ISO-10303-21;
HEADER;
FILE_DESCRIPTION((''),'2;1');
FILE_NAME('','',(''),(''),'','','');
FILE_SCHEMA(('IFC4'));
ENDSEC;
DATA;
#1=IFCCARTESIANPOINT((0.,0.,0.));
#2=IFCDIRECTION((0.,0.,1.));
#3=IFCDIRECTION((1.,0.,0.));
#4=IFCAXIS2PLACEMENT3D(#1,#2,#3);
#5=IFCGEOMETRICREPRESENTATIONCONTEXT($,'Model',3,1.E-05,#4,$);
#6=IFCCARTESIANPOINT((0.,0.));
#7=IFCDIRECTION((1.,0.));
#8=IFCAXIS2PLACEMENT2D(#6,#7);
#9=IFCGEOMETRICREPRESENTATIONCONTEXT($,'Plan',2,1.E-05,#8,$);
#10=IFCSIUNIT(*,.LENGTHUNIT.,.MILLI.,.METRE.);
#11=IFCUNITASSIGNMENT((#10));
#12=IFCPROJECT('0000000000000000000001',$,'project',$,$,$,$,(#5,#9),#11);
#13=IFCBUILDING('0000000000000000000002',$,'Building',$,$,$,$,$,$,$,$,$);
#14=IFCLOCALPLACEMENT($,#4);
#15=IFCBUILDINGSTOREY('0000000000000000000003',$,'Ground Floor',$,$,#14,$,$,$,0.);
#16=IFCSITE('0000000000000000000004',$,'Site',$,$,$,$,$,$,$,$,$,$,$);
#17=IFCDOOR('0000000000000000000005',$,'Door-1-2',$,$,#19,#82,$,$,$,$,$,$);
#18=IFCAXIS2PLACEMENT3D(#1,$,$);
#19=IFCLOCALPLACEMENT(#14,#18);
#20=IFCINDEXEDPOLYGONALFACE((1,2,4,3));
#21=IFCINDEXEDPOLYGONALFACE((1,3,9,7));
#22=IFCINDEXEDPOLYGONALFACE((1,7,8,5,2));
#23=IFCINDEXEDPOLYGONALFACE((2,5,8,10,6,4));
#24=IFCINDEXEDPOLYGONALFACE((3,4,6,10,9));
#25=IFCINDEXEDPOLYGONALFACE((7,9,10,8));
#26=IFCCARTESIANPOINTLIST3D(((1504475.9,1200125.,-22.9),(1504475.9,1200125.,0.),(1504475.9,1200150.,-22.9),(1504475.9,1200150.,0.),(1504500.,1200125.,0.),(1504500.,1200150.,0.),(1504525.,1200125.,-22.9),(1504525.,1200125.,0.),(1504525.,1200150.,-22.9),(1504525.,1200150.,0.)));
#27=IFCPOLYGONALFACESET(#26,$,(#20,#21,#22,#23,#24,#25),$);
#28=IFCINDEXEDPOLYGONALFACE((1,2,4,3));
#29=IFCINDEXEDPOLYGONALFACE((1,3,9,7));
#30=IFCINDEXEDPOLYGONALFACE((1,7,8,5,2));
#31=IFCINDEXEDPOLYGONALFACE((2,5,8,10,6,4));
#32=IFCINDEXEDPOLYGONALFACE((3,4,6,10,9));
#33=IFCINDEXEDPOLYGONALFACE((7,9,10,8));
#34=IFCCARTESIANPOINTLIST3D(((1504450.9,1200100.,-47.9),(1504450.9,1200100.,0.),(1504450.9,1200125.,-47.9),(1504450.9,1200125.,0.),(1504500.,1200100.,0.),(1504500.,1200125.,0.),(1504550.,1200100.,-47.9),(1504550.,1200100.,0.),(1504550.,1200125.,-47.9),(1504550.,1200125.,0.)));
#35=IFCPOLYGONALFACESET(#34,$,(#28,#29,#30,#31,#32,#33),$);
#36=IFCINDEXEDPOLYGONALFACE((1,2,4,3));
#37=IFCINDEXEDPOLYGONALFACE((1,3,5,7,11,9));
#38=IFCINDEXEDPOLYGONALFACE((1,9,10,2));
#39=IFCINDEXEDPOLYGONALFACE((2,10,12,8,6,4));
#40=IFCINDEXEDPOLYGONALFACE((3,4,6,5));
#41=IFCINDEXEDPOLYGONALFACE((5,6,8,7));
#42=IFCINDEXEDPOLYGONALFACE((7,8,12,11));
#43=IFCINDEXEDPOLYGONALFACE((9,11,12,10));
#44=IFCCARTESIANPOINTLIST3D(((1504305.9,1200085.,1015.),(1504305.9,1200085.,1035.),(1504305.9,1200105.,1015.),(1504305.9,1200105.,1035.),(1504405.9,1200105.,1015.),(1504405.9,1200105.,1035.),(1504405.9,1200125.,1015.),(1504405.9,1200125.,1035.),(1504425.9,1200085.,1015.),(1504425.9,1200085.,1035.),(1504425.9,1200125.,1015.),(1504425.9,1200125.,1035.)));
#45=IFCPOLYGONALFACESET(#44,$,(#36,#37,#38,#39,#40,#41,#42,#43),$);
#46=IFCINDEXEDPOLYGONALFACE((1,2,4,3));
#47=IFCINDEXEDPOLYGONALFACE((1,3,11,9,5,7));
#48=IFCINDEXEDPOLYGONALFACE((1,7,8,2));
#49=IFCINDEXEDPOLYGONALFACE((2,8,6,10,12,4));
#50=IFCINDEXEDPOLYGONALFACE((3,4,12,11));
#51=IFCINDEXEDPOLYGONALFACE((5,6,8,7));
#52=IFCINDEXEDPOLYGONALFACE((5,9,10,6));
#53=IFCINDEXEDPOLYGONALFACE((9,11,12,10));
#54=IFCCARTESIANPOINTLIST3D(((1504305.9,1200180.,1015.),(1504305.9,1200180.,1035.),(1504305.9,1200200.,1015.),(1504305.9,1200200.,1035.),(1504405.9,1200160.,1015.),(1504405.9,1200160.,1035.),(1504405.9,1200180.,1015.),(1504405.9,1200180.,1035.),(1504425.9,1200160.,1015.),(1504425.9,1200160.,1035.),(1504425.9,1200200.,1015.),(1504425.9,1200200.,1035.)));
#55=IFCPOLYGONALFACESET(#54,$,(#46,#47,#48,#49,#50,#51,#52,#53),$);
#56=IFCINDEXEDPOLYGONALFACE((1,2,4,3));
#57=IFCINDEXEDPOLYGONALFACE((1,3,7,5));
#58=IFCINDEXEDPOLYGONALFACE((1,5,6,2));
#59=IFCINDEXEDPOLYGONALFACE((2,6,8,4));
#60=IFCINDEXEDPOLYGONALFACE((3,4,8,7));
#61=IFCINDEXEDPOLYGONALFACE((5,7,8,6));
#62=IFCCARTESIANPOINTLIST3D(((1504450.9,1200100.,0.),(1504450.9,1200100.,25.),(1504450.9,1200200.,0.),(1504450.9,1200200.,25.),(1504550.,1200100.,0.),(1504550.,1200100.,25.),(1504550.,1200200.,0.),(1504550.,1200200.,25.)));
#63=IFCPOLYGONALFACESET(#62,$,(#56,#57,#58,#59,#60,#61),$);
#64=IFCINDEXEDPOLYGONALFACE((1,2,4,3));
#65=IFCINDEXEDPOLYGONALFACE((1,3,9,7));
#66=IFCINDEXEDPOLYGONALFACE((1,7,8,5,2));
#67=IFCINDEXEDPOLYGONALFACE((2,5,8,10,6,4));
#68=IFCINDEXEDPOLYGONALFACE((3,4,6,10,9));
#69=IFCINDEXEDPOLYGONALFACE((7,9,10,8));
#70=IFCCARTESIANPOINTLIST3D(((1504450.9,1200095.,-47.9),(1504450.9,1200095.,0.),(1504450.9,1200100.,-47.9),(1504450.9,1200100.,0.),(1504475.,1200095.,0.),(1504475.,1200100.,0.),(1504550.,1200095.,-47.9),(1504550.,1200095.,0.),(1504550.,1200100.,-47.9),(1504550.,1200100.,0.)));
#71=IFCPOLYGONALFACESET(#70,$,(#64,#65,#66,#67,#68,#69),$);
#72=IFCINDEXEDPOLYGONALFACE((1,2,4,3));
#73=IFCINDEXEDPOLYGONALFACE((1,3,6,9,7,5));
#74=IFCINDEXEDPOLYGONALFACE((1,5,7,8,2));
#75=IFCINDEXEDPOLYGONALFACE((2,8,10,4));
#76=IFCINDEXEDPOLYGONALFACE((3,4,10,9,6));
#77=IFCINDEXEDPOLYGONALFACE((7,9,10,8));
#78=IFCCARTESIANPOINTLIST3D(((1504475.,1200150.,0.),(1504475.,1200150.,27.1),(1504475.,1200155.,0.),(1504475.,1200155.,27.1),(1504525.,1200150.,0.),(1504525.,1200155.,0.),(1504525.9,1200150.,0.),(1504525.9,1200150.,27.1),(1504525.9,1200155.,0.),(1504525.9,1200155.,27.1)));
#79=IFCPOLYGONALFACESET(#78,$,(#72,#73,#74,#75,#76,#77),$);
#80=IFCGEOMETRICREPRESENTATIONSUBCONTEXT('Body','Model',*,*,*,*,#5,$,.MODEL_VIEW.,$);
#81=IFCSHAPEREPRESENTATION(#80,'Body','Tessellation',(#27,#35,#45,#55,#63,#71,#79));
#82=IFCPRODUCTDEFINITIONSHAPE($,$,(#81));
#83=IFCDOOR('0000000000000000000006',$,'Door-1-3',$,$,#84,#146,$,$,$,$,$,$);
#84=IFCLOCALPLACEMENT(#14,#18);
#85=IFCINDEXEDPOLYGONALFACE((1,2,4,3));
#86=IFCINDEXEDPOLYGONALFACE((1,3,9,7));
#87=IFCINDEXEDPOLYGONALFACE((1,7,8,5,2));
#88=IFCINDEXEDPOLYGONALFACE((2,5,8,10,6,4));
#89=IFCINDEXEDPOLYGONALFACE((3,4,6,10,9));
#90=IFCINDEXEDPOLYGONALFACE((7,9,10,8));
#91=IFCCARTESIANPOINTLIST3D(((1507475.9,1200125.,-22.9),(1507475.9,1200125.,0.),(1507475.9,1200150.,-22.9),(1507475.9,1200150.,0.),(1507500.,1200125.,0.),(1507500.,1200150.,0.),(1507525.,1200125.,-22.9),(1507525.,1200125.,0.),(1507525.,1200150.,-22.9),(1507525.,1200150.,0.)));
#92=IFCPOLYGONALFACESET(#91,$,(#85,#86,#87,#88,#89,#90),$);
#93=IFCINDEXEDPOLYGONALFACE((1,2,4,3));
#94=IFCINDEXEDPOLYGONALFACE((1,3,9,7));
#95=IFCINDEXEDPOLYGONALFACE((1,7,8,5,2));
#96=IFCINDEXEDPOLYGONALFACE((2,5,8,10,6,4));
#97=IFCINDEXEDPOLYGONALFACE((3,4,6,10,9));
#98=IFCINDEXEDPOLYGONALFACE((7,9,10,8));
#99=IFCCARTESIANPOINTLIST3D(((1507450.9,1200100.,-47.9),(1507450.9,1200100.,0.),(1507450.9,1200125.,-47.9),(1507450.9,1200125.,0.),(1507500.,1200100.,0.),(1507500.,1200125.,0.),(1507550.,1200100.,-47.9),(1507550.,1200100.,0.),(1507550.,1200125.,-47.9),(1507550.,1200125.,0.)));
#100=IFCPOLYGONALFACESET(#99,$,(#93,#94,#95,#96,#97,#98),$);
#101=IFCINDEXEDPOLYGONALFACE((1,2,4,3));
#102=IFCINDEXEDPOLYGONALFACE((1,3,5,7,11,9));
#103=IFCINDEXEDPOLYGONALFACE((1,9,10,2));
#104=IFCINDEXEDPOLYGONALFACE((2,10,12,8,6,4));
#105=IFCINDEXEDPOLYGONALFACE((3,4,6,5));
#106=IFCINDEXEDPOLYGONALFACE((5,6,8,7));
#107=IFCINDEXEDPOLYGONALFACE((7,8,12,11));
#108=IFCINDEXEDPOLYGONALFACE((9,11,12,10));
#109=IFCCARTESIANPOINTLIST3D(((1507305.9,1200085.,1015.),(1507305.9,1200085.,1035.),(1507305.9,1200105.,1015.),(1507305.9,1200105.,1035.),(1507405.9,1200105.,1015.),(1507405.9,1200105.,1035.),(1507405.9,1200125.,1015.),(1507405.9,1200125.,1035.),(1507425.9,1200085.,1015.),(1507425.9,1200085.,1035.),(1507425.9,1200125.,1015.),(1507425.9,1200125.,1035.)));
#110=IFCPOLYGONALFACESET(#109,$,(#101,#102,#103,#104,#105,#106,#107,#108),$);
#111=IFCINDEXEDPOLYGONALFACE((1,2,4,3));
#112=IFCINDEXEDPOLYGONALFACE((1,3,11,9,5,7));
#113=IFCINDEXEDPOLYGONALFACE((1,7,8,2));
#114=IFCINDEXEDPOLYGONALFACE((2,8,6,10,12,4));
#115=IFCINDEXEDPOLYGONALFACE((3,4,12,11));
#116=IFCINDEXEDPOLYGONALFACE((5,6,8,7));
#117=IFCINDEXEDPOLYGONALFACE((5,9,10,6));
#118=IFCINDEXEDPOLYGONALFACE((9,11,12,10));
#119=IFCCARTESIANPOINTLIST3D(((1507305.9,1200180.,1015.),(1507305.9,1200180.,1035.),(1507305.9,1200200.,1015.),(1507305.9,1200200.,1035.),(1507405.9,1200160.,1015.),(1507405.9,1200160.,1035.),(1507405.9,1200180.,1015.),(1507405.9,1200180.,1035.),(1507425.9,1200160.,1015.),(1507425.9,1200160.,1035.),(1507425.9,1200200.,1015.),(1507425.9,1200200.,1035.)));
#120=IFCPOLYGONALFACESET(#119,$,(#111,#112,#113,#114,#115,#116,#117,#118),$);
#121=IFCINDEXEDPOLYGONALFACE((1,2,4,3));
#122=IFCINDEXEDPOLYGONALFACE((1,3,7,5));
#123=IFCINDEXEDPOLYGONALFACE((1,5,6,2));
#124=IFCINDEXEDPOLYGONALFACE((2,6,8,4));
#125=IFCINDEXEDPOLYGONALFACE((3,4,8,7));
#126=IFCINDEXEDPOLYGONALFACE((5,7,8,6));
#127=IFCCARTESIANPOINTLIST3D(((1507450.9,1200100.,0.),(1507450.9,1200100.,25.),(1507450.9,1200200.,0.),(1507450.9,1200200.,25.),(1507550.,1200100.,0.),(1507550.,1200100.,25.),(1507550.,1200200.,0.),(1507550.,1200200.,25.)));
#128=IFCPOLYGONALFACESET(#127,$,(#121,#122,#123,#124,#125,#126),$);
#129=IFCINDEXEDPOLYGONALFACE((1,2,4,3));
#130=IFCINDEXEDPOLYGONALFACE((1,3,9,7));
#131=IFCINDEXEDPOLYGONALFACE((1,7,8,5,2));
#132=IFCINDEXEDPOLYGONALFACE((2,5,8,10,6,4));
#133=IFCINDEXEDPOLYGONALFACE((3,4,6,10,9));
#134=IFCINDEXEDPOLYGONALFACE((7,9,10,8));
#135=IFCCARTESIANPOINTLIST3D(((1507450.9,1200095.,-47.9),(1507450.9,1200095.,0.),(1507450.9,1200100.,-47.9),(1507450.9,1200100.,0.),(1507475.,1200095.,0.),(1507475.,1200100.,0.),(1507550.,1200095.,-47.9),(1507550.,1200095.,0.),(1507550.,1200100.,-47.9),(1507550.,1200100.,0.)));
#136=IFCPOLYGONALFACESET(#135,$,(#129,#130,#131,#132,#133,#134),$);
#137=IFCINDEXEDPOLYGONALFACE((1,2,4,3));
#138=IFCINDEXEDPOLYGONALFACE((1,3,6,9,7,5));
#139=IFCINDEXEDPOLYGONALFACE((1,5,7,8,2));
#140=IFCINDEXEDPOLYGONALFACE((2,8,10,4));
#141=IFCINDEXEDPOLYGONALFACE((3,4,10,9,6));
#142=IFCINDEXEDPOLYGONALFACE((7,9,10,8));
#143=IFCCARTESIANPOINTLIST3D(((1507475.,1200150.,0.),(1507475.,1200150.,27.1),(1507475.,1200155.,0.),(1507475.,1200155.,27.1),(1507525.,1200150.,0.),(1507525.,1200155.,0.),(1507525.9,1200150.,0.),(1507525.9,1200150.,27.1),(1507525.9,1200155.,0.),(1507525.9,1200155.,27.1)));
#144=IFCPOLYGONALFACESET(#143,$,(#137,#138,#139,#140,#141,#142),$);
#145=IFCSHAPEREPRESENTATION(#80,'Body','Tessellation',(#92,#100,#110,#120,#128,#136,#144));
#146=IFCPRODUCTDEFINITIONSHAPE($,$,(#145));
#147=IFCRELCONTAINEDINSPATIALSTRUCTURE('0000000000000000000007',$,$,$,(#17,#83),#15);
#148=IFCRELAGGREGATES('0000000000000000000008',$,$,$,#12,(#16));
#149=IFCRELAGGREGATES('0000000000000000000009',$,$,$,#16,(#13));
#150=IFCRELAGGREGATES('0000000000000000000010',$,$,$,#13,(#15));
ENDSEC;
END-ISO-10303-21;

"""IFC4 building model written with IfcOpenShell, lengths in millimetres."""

from ifc_helpers import new_model, si_unit, frame, origin_with_axes, origin_2d_with_axis, place, context, subcontext, project, spatial, line, indexed_curve, outline, extrude, element, save


model = new_model("IFC4")

# Units and contexts
model_context = context("Model", 3, precision=1e-05, world=origin_with_axes())
plan_context = context("Plan", 2, precision=1e-05, world=origin_2d_with_axis())
body_context = subcontext(model_context, "Body", "Model", "MODEL_VIEW")
ifc_project = project(units=[si_unit("LENGTHUNIT", "METRE", prefix="MILLI")], contexts=[model_context, plan_context])

# Site, building, storey
site = spatial("IfcSite", under=ifc_project, Name="Site")
building = spatial("IfcBuilding", under=site, Name="Building")
storey_placement = place(None, origin_with_axes())
storey = spatial("IfcBuildingStorey", under=building, at=storey_placement, Name="Ground Floor", Elevation=0.0)

# Doors
door_1_placement = place(storey_placement, frame((1504500.0, 1200100.0, 0.0), z_axis=(0.0, 0.0, 1.0), x_axis=(1.0, 0.0, 0.0)))
element("IfcDoor", 1, at=door_1_placement, inside=storey, Name="Door-1-2", context=body_context, shape_type="SweptSolid", body=[
    extrude(outline(indexed_curve([(0.0, 0.0), (0.0, 2.1), (0.9, 2.1), (0.9, 0.0), (-24.1, 0.0), (-24.1, -22.9), (25.0, -22.9), (25.0, 0.0)], segments=[line(1, 2, 3, 4, 5, 6, 7, 8, 1)])), frame((0.0, 25.0, 0.0), z_axis=(0.0, -1.0, 0.0), x_axis=(1.0, 0.0, 0.0)), (0.0, 0.0, -1.0), 25.0),
    extrude(outline(indexed_curve([(0.0, 0.0), (0.0, 2.1), (0.9, 2.1), (0.9, 0.0), (-49.1, 0.0), (-49.1, -47.9), (50.0, -47.9), (50.0, 0.0)], segments=[line(1, 2, 3, 4, 5, 6, 7, 8, 1)])), frame((0.0, 0.0, 0.0), z_axis=(0.0, -1.0, 0.0), x_axis=(1.0, 0.0, 0.0)), (0.0, 0.0, -1.0), 25.0),
    extrude(outline(indexed_curve([(0.0, 0.0), (-49.1, 0.0), (-49.1, 35.0), (0.0, 35.0)], segments=[line(1, 2, 3, 4, 1)])), frame((25.0, 25.0, 25.0), z_axis=(0.0, 0.0, 1.0), x_axis=(1.0, 0.0, 0.0)), (0.0, 0.0, 1.0), -47.9),
    extrude(outline(indexed_curve([(0.0, 0.0), (0.0, -40.0), (-120.0, -40.0), (-120.0, -20.0), (-20.0, -20.0), (-20.0, 0.0)], segments=[line(1, 2, 3, 4, 5, 6, 1)])), frame((-74.1, 25.0, 1015.0), z_axis=(0.0, 0.0, 1.0), x_axis=(1.0, 0.0, 0.0)), (0.0, 0.0, 1.0), 20.0),
    extrude(outline(indexed_curve([(0.0, 0.0), (0.0, 40.0), (-120.0, 40.0), (-120.0, 20.0), (-20.0, 20.0), (-20.0, 0.0)], segments=[line(1, 2, 3, 4, 5, 6, 1)])), frame((-74.1, 60.0, 1015.0), z_axis=(0.0, 0.0, 1.0), x_axis=(1.0, 0.0, 0.0)), (0.0, 0.0, 1.0), 20.0),
    extrude(outline(indexed_curve([(0.0, 0.0), (-99.1, 0.0), (-99.1, 100.0), (0.0, 100.0)], segments=[line(1, 2, 3, 4, 1)])), frame((50.0, 0.0, 0.0), z_axis=(0.0, 0.0, 1.0), x_axis=(1.0, 0.0, 0.0)), (0.0, 0.0, 1.0), 25.0),
    extrude(outline(indexed_curve([(0.0, 0.0), (0.0, 27.1), (50.9, 27.1), (50.9, 0.0), (-24.1, 0.0), (-24.1, -47.9), (75.0, -47.9), (75.0, 0.0)], segments=[line(1, 2, 3, 4, 5, 6, 7, 8, 1)])), frame((-25.0, -5.0, 0.0), z_axis=(0.0, -1.0, 0.0), x_axis=(1.0, 0.0, 0.0)), (0.0, 0.0, -1.0), 5.0),
    extrude(outline(indexed_curve([(0.0, 0.0), (0.0, 27.1), (50.9, 27.1), (50.9, 0.0), (0.9, 0.0), (0.9, -22.9), (50.0, -22.9), (50.0, 0.0)], segments=[line(1, 2, 3, 4, 5, 6, 7, 8, 1)])), frame((-25.0, 50.0, 0.0), z_axis=(0.0, -1.0, 0.0), x_axis=(1.0, 0.0, 0.0)), (0.0, 0.0, -1.0), 5.0),
])
door_2_placement = place(storey_placement, frame((1507500.0, 1200100.0, 0.0), z_axis=(0.0, 0.0, 1.0), x_axis=(1.0, 0.0, 0.0)))
element("IfcDoor", 2, at=door_2_placement, inside=storey, Name="Door-1-3", context=body_context, shape_type="SweptSolid", body=[
    extrude(outline(indexed_curve([(0.0, 0.0), (0.0, 2.1), (0.9, 2.1), (0.9, 0.0), (-24.1, 0.0), (-24.1, -22.9), (25.0, -22.9), (25.0, 0.0)], segments=[line(1, 2, 3, 4, 5, 6, 7, 8, 1)])), frame((0.0, 25.0, 0.0), z_axis=(0.0, -1.0, 0.0), x_axis=(1.0, 0.0, 0.0)), (0.0, 0.0, -1.0), 25.0),
    extrude(outline(indexed_curve([(0.0, 0.0), (0.0, 2.1), (0.9, 2.1), (0.9, 0.0), (-49.1, 0.0), (-49.1, -47.9), (50.0, -47.9), (50.0, 0.0)], segments=[line(1, 2, 3, 4, 5, 6, 7, 8, 1)])), frame((0.0, 0.0, 0.0), z_axis=(0.0, -1.0, 0.0), x_axis=(1.0, 0.0, 0.0)), (0.0, 0.0, -1.0), 25.0),
    extrude(outline(indexed_curve([(0.0, 0.0), (-49.1, 0.0), (-49.1, 35.0), (0.0, 35.0)], segments=[line(1, 2, 3, 4, 1)])), frame((25.0, 25.0, 25.0), z_axis=(0.0, 0.0, 1.0), x_axis=(1.0, 0.0, 0.0)), (0.0, 0.0, 1.0), -47.9),
    extrude(outline(indexed_curve([(0.0, 0.0), (0.0, -40.0), (-120.0, -40.0), (-120.0, -20.0), (-20.0, -20.0), (-20.0, 0.0)], segments=[line(1, 2, 3, 4, 5, 6, 1)])), frame((-74.1, 25.0, 1015.0), z_axis=(0.0, 0.0, 1.0), x_axis=(1.0, 0.0, 0.0)), (0.0, 0.0, 1.0), 20.0),
    extrude(outline(indexed_curve([(0.0, 0.0), (0.0, 40.0), (-120.0, 40.0), (-120.0, 20.0), (-20.0, 20.0), (-20.0, 0.0)], segments=[line(1, 2, 3, 4, 5, 6, 1)])), frame((-74.1, 60.0, 1015.0), z_axis=(0.0, 0.0, 1.0), x_axis=(1.0, 0.0, 0.0)), (0.0, 0.0, 1.0), 20.0),
    extrude(outline(indexed_curve([(0.0, 0.0), (-99.1, 0.0), (-99.1, 100.0), (0.0, 100.0)], segments=[line(1, 2, 3, 4, 1)])), frame((50.0, 0.0, 0.0), z_axis=(0.0, 0.0, 1.0), x_axis=(1.0, 0.0, 0.0)), (0.0, 0.0, 1.0), 25.0),
    extrude(outline(indexed_curve([(0.0, 0.0), (0.0, 27.1), (50.9, 27.1), (50.9, 0.0), (-24.1, 0.0), (-24.1, -47.9), (75.0, -47.9), (75.0, 0.0)], segments=[line(1, 2, 3, 4, 5, 6, 7, 8, 1)])), frame((-25.0, -5.0, 0.0), z_axis=(0.0, -1.0, 0.0), x_axis=(1.0, 0.0, 0.0)), (0.0, 0.0, -1.0), 5.0),
    extrude(outline(indexed_curve([(0.0, 0.0), (0.0, 27.1), (50.9, 27.1), (50.9, 0.0), (0.9, 0.0), (0.9, -22.9), (50.0, -22.9), (50.0, 0.0)], segments=[line(1, 2, 3, 4, 5, 6, 7, 8, 1)])), frame((-25.0, 50.0, 0.0), z_axis=(0.0, -1.0, 0.0), x_axis=(1.0, 0.0, 0.0)), (0.0, 0.0, -1.0), 5.0),
])

save(model, "model.ifc")
